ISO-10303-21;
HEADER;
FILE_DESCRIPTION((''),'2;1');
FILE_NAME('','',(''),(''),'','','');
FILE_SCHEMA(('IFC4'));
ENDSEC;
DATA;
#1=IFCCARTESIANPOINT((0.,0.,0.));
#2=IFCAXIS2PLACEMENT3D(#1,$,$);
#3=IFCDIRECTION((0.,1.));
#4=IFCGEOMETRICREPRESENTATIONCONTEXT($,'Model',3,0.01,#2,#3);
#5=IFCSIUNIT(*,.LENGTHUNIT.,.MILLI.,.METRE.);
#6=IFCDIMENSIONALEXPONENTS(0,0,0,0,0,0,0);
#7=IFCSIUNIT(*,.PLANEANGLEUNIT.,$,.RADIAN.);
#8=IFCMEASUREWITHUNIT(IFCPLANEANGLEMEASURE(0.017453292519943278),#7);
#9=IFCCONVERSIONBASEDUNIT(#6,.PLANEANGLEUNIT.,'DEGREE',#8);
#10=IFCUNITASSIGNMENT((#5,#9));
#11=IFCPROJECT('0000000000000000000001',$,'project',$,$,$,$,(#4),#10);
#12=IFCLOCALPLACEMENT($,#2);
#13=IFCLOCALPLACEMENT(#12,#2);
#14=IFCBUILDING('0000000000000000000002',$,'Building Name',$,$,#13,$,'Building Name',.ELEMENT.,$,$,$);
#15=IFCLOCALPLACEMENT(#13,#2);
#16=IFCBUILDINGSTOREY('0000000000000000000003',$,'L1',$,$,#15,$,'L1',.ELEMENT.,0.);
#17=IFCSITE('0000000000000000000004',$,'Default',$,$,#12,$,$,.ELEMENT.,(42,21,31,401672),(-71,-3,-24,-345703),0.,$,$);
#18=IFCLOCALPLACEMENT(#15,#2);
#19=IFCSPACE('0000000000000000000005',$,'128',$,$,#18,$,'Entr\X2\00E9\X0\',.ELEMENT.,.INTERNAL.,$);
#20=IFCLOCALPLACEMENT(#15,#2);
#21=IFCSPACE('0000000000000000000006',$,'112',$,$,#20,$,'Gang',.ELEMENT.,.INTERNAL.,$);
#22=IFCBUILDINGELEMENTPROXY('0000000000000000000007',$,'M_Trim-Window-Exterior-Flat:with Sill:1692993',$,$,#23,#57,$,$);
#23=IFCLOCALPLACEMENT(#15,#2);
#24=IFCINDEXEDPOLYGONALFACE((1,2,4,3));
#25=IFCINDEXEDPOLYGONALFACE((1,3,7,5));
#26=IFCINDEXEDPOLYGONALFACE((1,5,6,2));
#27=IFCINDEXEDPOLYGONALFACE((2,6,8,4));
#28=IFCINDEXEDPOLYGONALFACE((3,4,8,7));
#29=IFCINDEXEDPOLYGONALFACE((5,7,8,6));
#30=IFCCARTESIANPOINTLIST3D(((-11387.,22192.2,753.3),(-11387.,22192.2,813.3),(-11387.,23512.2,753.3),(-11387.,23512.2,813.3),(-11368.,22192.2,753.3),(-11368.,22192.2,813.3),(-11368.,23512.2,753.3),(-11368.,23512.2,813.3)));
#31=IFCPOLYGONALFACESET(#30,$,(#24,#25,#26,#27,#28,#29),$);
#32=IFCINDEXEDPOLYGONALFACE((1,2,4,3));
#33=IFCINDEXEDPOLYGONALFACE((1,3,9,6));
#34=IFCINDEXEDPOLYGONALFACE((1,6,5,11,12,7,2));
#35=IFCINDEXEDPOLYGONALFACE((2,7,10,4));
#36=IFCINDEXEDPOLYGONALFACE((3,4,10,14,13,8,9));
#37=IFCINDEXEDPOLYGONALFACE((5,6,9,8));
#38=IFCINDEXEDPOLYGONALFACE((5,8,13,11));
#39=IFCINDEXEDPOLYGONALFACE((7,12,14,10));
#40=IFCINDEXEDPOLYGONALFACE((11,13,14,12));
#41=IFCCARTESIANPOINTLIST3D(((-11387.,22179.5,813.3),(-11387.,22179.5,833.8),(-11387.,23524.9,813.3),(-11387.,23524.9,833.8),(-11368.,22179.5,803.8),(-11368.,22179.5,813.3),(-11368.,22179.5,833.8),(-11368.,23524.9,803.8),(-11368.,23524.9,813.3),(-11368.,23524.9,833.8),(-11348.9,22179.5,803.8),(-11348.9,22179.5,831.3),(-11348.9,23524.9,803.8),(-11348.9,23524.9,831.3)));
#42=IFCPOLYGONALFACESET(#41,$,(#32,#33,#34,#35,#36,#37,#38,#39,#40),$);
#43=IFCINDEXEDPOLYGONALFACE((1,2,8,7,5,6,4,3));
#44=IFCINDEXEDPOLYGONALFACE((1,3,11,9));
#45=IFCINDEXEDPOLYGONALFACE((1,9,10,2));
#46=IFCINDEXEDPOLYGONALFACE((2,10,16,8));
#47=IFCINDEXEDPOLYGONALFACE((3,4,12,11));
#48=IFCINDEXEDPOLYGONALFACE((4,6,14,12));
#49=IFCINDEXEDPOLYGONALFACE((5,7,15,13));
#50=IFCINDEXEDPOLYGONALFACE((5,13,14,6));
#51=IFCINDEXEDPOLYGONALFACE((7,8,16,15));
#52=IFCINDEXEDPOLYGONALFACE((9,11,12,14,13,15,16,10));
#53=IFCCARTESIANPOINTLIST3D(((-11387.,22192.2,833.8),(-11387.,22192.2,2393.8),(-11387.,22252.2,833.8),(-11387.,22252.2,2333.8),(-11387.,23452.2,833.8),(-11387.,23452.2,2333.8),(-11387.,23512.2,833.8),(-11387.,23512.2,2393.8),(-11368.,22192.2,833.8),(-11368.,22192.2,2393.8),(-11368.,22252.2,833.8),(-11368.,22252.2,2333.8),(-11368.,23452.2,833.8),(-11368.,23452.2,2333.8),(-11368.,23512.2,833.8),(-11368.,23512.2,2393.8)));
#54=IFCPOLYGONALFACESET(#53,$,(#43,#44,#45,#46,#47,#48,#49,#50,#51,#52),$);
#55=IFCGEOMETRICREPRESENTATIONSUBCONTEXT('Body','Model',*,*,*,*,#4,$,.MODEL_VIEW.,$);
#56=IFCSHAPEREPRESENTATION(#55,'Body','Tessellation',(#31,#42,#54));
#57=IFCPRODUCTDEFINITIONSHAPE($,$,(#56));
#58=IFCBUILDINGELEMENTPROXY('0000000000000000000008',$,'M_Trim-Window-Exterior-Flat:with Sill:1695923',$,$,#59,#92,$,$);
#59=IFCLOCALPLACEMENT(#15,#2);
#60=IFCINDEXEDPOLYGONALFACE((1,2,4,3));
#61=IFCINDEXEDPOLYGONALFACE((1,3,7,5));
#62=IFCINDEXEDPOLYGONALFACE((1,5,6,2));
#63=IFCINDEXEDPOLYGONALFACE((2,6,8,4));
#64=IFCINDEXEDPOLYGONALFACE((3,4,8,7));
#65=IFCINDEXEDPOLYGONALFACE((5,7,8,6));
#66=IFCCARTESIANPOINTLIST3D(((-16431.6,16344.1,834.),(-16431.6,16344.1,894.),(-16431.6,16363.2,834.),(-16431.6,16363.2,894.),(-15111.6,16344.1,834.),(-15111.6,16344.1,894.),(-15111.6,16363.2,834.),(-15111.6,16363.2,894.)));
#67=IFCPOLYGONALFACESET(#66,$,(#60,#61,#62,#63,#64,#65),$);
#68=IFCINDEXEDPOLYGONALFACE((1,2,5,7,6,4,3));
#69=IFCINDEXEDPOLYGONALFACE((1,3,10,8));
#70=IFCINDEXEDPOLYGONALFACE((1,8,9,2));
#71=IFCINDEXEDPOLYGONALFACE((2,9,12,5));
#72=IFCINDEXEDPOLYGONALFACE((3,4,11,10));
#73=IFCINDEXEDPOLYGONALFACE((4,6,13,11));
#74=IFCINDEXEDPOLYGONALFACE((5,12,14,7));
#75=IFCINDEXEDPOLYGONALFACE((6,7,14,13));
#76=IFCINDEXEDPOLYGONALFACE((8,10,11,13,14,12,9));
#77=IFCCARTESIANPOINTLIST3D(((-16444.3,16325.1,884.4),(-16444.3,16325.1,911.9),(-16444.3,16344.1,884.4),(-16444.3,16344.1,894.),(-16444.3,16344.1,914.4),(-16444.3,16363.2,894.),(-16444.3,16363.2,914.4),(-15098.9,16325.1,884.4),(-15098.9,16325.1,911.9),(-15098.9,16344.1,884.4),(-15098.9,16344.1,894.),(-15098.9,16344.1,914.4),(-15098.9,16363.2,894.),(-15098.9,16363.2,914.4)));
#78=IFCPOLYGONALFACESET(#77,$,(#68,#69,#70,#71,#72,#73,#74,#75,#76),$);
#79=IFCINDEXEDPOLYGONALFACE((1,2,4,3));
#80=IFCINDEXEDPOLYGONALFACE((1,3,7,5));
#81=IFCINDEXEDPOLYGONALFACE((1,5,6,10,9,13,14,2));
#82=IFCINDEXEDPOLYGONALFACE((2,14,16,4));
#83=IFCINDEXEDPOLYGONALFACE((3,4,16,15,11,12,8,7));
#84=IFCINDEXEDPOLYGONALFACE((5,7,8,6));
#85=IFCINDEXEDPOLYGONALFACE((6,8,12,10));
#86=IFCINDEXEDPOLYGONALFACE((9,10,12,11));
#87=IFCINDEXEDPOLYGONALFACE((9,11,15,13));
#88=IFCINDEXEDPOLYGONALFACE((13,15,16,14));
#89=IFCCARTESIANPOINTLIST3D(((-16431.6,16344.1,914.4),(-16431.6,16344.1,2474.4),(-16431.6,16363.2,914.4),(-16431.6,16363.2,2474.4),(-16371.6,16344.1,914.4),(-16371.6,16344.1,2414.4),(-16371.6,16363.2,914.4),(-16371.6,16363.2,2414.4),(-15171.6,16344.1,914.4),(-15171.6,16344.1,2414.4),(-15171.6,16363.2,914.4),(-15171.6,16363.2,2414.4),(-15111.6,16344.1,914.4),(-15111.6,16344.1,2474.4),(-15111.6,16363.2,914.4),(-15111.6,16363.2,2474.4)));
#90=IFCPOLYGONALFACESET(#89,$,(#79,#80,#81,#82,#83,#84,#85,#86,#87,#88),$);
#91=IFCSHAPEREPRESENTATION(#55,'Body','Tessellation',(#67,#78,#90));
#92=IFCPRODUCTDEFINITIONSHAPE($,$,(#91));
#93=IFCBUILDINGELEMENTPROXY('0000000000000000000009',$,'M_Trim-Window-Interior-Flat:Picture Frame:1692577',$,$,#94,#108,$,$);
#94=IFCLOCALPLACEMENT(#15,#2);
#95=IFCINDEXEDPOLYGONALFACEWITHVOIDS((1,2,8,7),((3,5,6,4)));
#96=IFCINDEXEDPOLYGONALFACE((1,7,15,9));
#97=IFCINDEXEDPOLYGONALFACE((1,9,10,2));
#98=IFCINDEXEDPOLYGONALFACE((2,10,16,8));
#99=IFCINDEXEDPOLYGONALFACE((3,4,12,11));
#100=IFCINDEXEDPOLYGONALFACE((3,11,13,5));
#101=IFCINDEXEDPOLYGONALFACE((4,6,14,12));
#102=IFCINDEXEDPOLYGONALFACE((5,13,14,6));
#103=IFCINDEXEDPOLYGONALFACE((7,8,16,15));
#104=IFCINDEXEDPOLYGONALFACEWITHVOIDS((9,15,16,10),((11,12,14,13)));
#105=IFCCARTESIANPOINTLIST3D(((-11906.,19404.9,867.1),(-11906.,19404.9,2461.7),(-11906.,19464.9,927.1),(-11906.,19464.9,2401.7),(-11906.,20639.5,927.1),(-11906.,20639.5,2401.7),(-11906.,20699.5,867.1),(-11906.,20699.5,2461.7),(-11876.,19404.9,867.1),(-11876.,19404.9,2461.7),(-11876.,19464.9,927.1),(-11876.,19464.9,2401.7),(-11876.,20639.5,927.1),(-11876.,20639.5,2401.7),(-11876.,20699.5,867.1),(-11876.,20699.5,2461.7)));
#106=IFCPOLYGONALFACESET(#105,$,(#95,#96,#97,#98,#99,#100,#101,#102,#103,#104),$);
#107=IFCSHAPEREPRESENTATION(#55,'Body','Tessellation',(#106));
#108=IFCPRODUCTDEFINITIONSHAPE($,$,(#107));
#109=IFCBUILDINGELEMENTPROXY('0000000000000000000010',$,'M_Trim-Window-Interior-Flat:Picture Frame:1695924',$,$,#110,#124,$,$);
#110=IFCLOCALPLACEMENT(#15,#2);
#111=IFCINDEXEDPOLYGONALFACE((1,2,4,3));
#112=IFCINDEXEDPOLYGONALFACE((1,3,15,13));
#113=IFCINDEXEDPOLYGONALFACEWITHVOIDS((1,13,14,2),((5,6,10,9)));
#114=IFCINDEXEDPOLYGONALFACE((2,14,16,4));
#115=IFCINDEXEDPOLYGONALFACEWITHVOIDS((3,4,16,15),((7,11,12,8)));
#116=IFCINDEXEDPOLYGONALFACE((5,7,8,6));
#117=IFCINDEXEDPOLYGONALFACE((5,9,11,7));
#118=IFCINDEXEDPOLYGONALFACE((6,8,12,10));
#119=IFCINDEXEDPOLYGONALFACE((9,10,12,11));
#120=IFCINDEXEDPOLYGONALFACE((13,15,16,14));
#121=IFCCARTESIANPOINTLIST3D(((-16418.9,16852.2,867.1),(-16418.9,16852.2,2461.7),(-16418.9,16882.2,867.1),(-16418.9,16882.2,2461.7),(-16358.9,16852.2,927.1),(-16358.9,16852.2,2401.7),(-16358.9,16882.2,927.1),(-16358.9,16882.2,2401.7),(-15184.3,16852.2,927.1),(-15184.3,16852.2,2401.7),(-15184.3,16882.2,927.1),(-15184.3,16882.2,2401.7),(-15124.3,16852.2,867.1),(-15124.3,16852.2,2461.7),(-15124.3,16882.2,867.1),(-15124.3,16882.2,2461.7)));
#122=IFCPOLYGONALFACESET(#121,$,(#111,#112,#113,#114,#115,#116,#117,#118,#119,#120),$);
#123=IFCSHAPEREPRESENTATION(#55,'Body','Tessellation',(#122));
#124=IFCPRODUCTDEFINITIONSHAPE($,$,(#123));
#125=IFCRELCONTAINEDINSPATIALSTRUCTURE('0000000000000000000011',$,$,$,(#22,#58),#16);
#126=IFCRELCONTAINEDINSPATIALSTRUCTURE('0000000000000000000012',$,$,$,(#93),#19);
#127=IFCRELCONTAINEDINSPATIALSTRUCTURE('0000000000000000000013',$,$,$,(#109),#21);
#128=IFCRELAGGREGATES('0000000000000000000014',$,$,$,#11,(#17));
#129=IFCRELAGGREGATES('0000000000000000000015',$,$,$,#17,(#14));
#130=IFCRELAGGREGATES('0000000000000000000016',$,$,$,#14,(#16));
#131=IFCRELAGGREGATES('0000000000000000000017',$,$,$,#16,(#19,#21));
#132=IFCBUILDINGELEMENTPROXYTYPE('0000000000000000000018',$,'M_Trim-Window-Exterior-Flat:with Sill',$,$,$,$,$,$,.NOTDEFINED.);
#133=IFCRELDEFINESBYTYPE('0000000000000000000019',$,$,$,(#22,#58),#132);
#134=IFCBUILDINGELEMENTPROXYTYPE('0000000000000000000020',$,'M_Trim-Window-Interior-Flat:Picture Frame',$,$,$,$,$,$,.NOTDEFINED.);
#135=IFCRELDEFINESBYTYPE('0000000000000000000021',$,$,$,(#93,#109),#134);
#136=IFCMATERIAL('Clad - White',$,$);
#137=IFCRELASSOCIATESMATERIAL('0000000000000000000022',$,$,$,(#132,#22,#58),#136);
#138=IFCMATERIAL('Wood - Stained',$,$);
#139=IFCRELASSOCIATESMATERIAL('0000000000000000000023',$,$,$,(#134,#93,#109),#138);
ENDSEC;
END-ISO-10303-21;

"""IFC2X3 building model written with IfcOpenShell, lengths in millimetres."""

from ifc_helpers import new_model, entity, si_unit, converted_unit, direction, frame, frame_2d, origin, place, context, subcontext, project, spatial, polyline, rectangle, outline, extrude, source, transform, mapped, material, type_object, type_shapes, element, save


model = new_model("IFC2X3")

# Units and contexts
model_context = context("Model", 3, precision=0.01, world=origin(), true_north=direction((0.0, 1.0)))
body_context = subcontext(model_context, "Body", "Model", "MODEL_VIEW")
ifc_project = project(units=[si_unit("LENGTHUNIT", "METRE", prefix="MILLI"), converted_unit("PLANEANGLEUNIT", "DEGREE", entity("IfcPlaneAngleMeasure", 0.017453292519943278), si_unit("PLANEANGLEUNIT", "RADIAN"), dimensions=[0, 0, 0, 0, 0, 0, 0])], contexts=[model_context])

# Site, building, storey
site_placement = place(None, origin())
site = spatial("IfcSite", under=ifc_project, at=site_placement, Name="Default", CompositionType="ELEMENT", RefLatitude=(42, 21, 31, 401672), RefLongitude=(-71, -3, -24, -345703), RefElevation=0.0)
building_placement = place(site_placement, origin())
building = spatial("IfcBuilding", under=site, at=building_placement, Name="Building Name", LongName="Building Name", CompositionType="ELEMENT")
storey_placement = place(building_placement, origin())
storey = spatial("IfcBuildingStorey", under=building, at=storey_placement, Name="L1", LongName="L1", CompositionType="ELEMENT", Elevation=0.0)

# Shared definitions
ifc_material_1 = material(Name="Wood - Stained")

# Building element proxies
ifc_material_2 = material(Name="Clad - White")
building_element_proxy_type_1 = type_object("IfcBuildingElementProxyType", Name="M_Trim-Window-Exterior-Flat:with Sill", PredefinedType="NOTDEFINED", material=ifc_material_2)
shared_shape_1 = source(origin(), body_context, "Body", "SweptSolid", [
    extrude(rectangle(XDim=1320.0, YDim=60.0, at=frame_2d((0.0, 0.0), x_axis=(1.0, 0.0))), frame((0.0, -1550.4, 0.0), z_axis=(0.0, 0.0, 1.0), x_axis=(-1.0, 0.0, 0.0)), (0.0, 0.0, 1.0), 19.0),
    extrude(outline(polyline([(-19.0, -15.2), (0.0, -15.2), (0.0, -5.7), (19.0, -5.7), (19.0, 14.8), (0.0, 14.8), (-19.0, 12.3), (-19.0, -15.2)])), frame((-672.7, -1514.8, 19.0), z_axis=(1.0, 0.0, 0.0), x_axis=(0.0, 0.0, -1.0)), (0.0, 0.0, 1.0), 1345.4),
    extrude(outline(polyline([(-795.0, -660.0), (765.0, -660.0), (765.0, -600.0), (-735.0, -600.0), (-735.0, 600.0), (765.0, 600.0), (765.0, 660.0), (-795.0, 660.0), (-795.0, -660.0)])), frame((0.0, -735.0, 0.0), z_axis=(0.0, 0.0, 1.0), x_axis=(0.0, -1.0, 0.0)), (0.0, 0.0, 1.0), 19.0),
])
type_shapes(building_element_proxy_type_1, [shared_shape_1])
for number, where, z_axis, x_axis, name in (
    (1, (-11387.0, 22852.2, 2333.8), (1.0, 0.0, 0.0), (0.0, 1.0, 0.0), "M_Trim-Window-Exterior-Flat:with Sill:1692993"),
    (2, (-15771.6, 16363.2, 2414.4), (0.0, -1.0, 0.0), (1.0, 0.0, 0.0), "M_Trim-Window-Exterior-Flat:with Sill:1695923"),
):
    element("IfcBuildingElementProxy", number, at=place(storey_placement, frame(where, z_axis=z_axis, x_axis=x_axis)), inside=storey, type_object=building_element_proxy_type_1, material=ifc_material_2, Name=name, context=body_context, shape_type="MappedRepresentation", body=[
        mapped(shared_shape_1, transform((0.0, 0.0, 0.0), scale=1.0)),
    ])

# Shared definitions
space_1_placement = place(storey_placement, origin())
space_1 = spatial("IfcSpace", under=storey, at=space_1_placement, Name="128", LongName="Entré", CompositionType="ELEMENT", InteriorOrExteriorSpace="INTERNAL")

# Building element proxy
building_element_proxy_type_2 = type_object("IfcBuildingElementProxyType", Name="M_Trim-Window-Interior-Flat:Picture Frame", PredefinedType="NOTDEFINED", material=ifc_material_1)
shared_shape_2 = source(origin(), body_context, "Body", "SweptSolid", [
    extrude(outline(polyline([(-647.3, -797.3), (647.3, -797.3), (647.3, 797.3), (-647.3, 797.3), (-647.3, -797.3)]), holes=[polyline([(-587.3, -737.3), (-587.3, 737.3), (587.3, 737.3), (587.3, -737.3), (-587.3, -737.3)])]), frame((0.0, -750.0, 0.0), z_axis=(0.0, 0.0, 1.0), x_axis=(-1.0, 0.0, 0.0)), (0.0, 0.0, 1.0), 30.0),
])
type_shapes(building_element_proxy_type_2, [shared_shape_2])
proxy_1_placement = place(space_1_placement, frame((-11876.0, 20052.2, 2414.4), z_axis=(-1.0, 0.0, 0.0), x_axis=(0.0, -1.0, 0.0)))
element("IfcBuildingElementProxy", 3, at=proxy_1_placement, inside=space_1, type_object=building_element_proxy_type_2, material=ifc_material_1, Name="M_Trim-Window-Interior-Flat:Picture Frame:1692577", context=body_context, shape_type="MappedRepresentation", body=[
    mapped(shared_shape_2, transform((0.0, 0.0, 0.0), scale=1.0)),
])

# Shared definitions
space_2_placement = place(storey_placement, origin())
space_2 = spatial("IfcSpace", under=storey, at=space_2_placement, Name="112", LongName="Gang", CompositionType="ELEMENT", InteriorOrExteriorSpace="INTERNAL")

# Building element proxy
proxy_2_placement = place(space_2_placement, frame((-15771.6, 16852.2, 2414.4), z_axis=(0.0, 1.0, 0.0), x_axis=(-1.0, 0.0, 0.0)))
element("IfcBuildingElementProxy", 4, at=proxy_2_placement, inside=space_2, type_object=building_element_proxy_type_2, material=ifc_material_1, Name="M_Trim-Window-Interior-Flat:Picture Frame:1695924", context=body_context, shape_type="MappedRepresentation", body=[
    mapped(shared_shape_2, transform((0.0, 0.0, 0.0), scale=1.0)),
])

save(model, "model.ifc")
